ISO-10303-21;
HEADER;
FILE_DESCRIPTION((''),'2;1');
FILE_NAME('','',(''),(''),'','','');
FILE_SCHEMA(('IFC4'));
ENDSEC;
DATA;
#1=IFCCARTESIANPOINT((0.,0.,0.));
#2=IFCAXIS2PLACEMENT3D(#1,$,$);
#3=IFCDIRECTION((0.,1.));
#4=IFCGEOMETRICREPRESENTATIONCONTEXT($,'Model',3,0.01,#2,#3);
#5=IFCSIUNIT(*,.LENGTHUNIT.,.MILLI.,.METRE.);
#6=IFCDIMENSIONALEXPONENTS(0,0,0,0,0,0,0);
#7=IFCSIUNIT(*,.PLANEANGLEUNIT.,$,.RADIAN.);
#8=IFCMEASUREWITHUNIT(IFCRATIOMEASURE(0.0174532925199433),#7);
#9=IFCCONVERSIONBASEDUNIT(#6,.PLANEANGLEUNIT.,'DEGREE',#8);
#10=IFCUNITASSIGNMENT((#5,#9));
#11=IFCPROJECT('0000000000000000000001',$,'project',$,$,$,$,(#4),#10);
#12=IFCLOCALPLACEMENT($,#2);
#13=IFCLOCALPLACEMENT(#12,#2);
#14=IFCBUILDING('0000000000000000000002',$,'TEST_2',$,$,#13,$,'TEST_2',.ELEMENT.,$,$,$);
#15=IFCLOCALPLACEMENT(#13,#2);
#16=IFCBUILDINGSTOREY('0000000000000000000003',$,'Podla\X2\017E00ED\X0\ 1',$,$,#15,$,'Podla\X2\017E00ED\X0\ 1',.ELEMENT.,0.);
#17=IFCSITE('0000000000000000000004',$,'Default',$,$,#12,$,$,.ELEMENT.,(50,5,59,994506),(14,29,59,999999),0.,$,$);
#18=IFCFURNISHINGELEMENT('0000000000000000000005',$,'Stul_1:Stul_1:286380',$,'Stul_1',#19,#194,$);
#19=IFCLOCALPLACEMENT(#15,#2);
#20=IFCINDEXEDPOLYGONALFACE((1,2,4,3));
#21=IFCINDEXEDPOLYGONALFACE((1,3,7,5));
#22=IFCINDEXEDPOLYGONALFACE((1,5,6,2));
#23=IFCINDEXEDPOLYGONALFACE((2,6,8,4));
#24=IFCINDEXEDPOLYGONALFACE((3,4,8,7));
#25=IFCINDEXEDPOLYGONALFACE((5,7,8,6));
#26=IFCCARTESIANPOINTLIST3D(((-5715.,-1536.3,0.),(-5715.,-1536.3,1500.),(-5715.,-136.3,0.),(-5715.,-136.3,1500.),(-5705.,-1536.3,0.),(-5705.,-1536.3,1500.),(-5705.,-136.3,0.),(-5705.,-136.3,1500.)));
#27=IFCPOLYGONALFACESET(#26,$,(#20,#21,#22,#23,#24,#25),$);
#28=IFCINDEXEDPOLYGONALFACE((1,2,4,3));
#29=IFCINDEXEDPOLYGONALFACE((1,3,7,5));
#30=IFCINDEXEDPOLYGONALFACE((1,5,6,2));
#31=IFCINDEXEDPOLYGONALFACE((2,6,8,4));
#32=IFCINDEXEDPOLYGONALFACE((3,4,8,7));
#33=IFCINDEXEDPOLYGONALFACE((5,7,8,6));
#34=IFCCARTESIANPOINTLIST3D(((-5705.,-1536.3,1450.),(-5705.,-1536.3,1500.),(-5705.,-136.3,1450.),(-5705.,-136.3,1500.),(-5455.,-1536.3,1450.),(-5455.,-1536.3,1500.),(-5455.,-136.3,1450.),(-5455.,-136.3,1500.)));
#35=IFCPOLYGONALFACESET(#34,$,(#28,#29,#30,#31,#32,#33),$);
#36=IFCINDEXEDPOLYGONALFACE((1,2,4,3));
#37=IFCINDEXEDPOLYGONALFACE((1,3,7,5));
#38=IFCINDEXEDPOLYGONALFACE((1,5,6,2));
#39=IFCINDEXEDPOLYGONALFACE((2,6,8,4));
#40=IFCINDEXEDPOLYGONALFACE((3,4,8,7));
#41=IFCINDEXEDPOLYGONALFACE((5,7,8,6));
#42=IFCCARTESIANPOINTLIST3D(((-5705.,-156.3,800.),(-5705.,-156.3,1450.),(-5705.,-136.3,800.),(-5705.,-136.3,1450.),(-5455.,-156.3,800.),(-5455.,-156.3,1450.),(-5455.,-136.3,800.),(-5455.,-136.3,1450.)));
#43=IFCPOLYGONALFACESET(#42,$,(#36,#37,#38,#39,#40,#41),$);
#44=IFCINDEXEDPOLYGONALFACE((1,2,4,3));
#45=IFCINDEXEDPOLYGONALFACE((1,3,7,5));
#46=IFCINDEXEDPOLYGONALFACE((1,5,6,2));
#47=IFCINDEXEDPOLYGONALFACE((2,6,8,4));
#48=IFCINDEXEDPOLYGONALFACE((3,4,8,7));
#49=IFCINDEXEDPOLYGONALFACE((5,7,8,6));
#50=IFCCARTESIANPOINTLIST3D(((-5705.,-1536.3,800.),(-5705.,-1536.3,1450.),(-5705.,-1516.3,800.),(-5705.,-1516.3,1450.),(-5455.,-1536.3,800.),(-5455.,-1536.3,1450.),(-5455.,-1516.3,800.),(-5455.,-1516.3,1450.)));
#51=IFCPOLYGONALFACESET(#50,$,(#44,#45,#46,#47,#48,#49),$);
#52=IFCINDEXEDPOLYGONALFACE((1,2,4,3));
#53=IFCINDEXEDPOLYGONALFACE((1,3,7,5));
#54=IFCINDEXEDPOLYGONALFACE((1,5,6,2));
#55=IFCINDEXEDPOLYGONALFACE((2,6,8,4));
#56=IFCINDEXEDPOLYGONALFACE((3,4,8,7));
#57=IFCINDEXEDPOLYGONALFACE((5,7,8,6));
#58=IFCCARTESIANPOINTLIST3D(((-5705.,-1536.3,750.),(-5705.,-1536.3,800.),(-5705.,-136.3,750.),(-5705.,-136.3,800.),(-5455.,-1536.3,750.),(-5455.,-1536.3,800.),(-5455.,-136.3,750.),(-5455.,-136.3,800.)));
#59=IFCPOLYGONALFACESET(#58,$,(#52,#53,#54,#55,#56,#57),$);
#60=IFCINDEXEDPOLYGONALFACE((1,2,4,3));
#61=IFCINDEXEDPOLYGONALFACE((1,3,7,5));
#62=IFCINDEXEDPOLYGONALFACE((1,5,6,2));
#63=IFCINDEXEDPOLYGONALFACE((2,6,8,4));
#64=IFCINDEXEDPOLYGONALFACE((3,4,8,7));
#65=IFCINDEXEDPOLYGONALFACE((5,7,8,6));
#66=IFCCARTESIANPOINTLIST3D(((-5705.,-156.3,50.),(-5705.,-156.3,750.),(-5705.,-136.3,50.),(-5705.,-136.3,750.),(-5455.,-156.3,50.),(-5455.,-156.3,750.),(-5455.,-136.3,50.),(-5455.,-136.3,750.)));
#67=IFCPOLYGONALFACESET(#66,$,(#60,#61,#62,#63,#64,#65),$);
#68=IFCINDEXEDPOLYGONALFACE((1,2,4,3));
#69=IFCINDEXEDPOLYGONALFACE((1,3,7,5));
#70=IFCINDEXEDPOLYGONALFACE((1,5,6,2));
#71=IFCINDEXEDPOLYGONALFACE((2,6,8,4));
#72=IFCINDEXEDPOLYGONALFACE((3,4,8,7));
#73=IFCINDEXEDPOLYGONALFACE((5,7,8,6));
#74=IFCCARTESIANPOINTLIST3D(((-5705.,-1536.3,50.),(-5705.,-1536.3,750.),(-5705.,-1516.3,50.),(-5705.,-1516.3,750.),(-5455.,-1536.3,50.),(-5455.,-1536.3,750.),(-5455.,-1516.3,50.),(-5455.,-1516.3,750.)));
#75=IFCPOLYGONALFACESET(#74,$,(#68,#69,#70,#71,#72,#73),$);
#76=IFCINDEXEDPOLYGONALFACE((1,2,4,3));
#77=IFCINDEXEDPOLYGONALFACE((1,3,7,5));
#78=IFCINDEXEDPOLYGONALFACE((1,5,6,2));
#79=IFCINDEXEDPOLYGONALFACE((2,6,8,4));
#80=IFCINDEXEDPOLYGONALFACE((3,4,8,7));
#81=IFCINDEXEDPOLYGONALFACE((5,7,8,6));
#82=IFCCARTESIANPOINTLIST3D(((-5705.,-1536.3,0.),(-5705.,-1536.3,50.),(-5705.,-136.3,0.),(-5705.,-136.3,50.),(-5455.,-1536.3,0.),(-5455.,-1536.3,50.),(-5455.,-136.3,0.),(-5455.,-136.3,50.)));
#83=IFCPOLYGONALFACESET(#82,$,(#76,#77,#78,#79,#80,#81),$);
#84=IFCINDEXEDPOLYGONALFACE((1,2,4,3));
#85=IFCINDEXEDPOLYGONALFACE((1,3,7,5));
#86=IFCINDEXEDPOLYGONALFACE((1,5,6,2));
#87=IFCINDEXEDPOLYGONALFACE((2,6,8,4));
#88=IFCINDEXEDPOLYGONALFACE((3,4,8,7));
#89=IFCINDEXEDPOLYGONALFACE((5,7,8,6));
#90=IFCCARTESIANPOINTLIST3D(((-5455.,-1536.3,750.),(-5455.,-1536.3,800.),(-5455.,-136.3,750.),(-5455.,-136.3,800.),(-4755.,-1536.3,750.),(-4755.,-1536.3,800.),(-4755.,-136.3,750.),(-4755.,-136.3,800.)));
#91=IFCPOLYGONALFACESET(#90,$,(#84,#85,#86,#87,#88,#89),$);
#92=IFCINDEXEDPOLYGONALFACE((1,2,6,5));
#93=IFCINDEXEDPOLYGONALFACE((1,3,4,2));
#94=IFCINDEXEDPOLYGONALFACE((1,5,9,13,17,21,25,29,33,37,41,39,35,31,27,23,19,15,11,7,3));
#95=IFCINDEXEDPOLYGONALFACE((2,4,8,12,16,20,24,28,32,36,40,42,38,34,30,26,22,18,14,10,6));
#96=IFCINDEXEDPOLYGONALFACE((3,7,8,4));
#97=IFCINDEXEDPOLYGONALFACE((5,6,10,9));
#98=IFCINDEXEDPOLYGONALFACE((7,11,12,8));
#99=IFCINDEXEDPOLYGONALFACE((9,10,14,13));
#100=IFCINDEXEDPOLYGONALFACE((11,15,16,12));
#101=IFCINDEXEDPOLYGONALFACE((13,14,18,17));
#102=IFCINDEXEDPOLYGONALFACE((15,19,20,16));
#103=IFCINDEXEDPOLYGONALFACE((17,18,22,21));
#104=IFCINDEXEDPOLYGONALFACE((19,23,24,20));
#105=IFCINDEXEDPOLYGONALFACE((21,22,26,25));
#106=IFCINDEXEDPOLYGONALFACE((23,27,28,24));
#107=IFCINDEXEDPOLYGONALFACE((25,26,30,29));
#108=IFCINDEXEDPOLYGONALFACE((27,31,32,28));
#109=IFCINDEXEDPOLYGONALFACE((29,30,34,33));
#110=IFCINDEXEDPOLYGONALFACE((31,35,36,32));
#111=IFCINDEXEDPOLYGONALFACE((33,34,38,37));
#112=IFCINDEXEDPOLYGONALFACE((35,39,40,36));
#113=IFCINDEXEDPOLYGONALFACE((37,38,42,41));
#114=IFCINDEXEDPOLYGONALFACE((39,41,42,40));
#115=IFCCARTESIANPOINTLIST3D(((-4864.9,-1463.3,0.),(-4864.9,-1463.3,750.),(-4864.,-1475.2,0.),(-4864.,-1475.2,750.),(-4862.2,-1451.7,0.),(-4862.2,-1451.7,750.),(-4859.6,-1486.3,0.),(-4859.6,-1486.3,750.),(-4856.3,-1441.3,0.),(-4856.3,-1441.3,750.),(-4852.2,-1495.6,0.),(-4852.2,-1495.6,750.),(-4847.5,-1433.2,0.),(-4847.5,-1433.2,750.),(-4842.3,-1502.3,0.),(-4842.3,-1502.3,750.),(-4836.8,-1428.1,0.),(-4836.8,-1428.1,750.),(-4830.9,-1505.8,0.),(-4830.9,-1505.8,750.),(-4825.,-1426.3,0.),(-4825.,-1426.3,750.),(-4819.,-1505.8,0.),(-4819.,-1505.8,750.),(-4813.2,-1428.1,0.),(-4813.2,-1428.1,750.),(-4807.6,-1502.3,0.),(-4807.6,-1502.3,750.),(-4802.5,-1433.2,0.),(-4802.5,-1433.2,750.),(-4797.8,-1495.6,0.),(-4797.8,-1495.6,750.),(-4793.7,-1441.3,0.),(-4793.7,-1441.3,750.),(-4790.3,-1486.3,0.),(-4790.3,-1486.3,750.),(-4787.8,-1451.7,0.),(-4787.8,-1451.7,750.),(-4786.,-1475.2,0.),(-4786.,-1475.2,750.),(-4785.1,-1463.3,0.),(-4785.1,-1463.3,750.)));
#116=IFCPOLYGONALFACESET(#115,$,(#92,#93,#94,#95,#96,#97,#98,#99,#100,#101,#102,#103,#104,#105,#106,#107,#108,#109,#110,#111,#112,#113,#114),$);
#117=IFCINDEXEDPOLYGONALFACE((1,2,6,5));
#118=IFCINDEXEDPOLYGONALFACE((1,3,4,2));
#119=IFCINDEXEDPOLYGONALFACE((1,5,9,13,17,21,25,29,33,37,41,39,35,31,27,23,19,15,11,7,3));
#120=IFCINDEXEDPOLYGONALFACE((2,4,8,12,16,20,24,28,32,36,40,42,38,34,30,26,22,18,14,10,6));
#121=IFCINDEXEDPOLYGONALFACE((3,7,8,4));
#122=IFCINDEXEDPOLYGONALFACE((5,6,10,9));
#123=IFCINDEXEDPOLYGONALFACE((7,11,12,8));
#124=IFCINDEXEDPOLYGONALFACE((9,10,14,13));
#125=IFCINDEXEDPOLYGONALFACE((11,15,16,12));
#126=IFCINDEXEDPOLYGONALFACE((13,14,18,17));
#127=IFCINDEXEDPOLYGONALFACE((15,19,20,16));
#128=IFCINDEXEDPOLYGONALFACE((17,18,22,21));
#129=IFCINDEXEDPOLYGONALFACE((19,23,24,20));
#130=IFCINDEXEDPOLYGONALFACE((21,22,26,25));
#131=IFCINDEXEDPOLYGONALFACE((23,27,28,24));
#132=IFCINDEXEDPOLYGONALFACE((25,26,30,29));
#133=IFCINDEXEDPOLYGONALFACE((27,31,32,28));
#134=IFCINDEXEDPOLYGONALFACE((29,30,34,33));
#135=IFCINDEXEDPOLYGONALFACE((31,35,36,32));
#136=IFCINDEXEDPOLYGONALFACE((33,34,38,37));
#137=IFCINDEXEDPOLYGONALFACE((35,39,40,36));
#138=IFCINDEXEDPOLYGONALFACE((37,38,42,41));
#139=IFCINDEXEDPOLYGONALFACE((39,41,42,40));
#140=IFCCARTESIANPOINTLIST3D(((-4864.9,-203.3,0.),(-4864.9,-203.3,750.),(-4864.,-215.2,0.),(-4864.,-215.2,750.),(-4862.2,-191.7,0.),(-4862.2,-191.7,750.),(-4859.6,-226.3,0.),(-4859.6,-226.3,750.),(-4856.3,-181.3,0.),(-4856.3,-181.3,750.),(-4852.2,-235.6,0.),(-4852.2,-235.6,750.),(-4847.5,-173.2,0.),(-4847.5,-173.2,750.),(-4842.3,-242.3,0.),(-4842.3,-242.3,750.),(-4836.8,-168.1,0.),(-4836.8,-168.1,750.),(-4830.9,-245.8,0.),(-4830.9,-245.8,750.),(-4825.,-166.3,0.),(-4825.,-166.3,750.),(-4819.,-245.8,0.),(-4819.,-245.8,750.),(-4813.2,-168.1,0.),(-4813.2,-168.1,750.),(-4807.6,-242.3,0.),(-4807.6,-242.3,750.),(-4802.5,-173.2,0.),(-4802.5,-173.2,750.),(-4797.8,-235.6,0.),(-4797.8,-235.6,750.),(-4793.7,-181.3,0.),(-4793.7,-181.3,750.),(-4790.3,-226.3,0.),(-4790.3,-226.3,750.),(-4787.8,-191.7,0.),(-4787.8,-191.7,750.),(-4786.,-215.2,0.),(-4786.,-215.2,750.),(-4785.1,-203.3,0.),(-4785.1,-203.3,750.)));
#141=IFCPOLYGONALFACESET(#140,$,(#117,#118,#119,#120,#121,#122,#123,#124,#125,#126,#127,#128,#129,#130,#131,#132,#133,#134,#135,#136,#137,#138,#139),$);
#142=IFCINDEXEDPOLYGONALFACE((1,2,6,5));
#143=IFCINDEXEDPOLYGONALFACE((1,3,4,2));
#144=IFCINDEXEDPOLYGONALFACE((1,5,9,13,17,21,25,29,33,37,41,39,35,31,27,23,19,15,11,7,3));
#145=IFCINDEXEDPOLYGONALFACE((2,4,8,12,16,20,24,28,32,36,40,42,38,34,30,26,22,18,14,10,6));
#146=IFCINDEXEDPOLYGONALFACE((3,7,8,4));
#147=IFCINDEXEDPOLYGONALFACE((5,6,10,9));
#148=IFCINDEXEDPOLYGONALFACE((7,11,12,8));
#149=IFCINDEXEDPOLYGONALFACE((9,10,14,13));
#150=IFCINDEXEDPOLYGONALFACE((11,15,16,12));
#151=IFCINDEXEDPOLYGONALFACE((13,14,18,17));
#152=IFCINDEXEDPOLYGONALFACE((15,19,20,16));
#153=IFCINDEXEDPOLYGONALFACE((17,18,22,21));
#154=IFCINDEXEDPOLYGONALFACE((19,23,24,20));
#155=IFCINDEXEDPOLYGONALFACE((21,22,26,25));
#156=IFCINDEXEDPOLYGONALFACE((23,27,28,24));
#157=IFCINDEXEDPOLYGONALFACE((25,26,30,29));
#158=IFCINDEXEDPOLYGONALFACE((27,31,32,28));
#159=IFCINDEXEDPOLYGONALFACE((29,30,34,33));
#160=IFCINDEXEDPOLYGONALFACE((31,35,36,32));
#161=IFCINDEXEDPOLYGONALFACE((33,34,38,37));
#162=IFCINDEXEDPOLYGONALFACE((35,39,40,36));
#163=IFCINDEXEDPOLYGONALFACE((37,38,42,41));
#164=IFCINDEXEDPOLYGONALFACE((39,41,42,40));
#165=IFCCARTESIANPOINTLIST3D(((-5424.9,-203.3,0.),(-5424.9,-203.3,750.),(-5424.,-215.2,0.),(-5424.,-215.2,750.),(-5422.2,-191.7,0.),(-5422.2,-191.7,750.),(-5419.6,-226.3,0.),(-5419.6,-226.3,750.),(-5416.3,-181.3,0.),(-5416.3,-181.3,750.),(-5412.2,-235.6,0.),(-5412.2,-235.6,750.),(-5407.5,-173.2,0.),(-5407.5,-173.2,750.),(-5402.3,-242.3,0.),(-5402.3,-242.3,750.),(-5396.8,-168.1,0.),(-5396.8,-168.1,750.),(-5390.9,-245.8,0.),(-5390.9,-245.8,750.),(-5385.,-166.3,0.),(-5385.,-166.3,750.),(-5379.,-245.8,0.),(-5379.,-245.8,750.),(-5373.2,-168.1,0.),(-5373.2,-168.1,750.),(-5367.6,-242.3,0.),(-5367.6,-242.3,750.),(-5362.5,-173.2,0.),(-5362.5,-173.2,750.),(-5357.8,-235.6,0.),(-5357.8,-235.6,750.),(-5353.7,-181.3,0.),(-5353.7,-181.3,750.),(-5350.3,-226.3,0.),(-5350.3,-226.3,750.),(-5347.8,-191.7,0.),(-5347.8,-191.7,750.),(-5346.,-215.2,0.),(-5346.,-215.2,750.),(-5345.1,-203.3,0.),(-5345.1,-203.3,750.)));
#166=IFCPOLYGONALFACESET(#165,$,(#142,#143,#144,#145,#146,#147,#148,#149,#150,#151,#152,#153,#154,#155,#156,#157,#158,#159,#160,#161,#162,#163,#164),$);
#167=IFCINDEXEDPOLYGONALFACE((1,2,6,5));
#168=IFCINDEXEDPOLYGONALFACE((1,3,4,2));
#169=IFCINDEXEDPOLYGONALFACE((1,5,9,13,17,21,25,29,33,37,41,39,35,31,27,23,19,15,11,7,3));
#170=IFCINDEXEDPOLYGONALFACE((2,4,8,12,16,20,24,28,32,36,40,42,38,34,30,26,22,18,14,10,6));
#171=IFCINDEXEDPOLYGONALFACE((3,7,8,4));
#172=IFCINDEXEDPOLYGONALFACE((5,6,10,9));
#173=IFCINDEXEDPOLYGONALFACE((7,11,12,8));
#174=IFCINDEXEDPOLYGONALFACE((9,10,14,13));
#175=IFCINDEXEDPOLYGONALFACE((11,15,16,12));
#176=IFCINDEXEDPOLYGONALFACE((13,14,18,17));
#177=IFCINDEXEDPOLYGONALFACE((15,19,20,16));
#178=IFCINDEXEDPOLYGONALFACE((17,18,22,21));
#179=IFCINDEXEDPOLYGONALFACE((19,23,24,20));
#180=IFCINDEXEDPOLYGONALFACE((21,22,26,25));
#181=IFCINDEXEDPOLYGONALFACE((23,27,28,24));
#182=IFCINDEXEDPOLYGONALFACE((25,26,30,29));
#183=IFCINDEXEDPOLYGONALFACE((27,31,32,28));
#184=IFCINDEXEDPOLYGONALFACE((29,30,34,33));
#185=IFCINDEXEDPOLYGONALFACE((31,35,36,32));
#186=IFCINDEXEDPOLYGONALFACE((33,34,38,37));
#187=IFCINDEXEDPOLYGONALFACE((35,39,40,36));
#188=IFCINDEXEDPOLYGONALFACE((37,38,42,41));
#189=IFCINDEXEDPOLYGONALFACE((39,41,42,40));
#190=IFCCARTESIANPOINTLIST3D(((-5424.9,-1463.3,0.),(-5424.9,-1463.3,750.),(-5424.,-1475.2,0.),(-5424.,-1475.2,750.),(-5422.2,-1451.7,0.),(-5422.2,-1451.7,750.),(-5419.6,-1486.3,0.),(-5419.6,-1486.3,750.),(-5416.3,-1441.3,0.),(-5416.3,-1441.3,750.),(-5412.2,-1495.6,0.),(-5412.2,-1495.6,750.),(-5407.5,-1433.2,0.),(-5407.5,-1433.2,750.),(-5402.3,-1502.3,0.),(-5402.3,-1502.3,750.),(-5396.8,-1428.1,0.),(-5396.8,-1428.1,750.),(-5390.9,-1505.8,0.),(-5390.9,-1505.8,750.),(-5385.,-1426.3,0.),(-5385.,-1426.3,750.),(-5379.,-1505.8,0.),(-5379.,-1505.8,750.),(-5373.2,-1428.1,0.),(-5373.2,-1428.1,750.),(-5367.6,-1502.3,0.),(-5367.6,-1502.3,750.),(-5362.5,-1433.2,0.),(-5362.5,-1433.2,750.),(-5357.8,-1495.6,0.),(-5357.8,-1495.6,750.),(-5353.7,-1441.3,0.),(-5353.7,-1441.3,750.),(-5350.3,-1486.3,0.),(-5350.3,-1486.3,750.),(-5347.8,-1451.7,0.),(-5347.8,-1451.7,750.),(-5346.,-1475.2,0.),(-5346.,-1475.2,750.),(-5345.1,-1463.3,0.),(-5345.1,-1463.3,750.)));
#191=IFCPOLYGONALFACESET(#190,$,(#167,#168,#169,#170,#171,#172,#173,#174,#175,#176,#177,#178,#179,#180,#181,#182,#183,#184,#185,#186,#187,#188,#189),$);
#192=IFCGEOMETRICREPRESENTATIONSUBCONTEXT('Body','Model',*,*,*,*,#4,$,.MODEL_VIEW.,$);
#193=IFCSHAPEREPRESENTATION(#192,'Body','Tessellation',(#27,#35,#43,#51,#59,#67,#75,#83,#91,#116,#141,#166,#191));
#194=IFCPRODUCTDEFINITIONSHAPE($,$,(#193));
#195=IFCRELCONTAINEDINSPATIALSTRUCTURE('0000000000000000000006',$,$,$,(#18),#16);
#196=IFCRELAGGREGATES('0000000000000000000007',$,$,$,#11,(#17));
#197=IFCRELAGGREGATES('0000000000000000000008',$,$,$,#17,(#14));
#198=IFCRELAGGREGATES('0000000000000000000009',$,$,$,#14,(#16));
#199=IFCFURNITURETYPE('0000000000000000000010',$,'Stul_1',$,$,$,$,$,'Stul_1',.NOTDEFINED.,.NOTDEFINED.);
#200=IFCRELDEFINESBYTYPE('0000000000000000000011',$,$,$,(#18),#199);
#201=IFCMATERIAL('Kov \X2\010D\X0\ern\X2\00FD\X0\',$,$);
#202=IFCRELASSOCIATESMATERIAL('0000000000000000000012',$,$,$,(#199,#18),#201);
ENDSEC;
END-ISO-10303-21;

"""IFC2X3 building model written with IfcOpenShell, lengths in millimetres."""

from ifc_helpers import new_model, entity, si_unit, converted_unit, direction, frame, frame_2d, origin, origin_2d_with_axis, place, context, subcontext, project, spatial, rectangle, circle, extrude, source, transform, mapped, material, type_object, type_shapes, element, save


model = new_model("IFC2X3")

# Units and contexts
model_context = context("Model", 3, precision=0.01, world=origin(), true_north=direction((0.0, 1.0)))
body_context = subcontext(model_context, "Body", "Model", "MODEL_VIEW")
ifc_project = project(units=[si_unit("LENGTHUNIT", "METRE", prefix="MILLI"), converted_unit("PLANEANGLEUNIT", "DEGREE", entity("IfcRatioMeasure", 0.0174532925199433), si_unit("PLANEANGLEUNIT", "RADIAN"), dimensions=[0, 0, 0, 0, 0, 0, 0])], contexts=[model_context])

# Site, building, storey
site_placement = place(None, origin())
site = spatial("IfcSite", under=ifc_project, at=site_placement, Name="Default", CompositionType="ELEMENT", RefLatitude=(50, 5, 59, 994506), RefLongitude=(14, 29, 59, 999999), RefElevation=0.0)
building_placement = place(site_placement, origin())
building = spatial("IfcBuilding", under=site, at=building_placement, Name="TEST_2", LongName="TEST_2", CompositionType="ELEMENT")
storey_placement = place(building_placement, origin())
storey = spatial("IfcBuildingStorey", under=building, at=storey_placement, Name="Podlaží 1", LongName="Podlaží 1", CompositionType="ELEMENT", Elevation=0.0)

# Furnishing element
ifc_material_1 = material(Name="Kov černý")
furniture_type = type_object("IfcFurnitureType", Name="Stul_1", ElementType="Stul_1", material=ifc_material_1)
shared_shape_1 = source(origin(), body_context, "Body", "SweptSolid", [
    extrude(rectangle(XDim=1400.0, YDim=10.0, at=origin_2d_with_axis()), frame((0.0, 605.0, 0.0), z_axis=(0.0, 0.0, 1.0), x_axis=(-1.0, 0.0, 0.0)), (0.0, 0.0, 1.0), 1500.0),
    extrude(rectangle(XDim=1400.0, YDim=250.0, at=frame_2d((0.0, 0.0), x_axis=(1.0, 0.0))), frame((0.0, 475.0, 1450.0), z_axis=(0.0, 0.0, 1.0), x_axis=(-1.0, 0.0, 0.0)), (0.0, 0.0, 1.0), 50.0),
    extrude(rectangle(XDim=20.0, YDim=250.0, at=origin_2d_with_axis()), frame((690.0, 475.0, 800.0), z_axis=(0.0, 0.0, 1.0), x_axis=(-1.0, 0.0, 0.0)), (0.0, 0.0, 1.0), 650.0),
    extrude(rectangle(XDim=20.0, YDim=250.0, at=frame_2d((0.0, 0.0), x_axis=(1.0, 0.0))), frame((-690.0, 475.0, 800.0), z_axis=(0.0, 0.0, 1.0), x_axis=(-1.0, 0.0, 0.0)), (0.0, 0.0, 1.0), 650.0),
    extrude(rectangle(XDim=1400.0, YDim=250.0, at=origin_2d_with_axis()), frame((0.0, 475.0, 750.0), z_axis=(0.0, 0.0, 1.0), x_axis=(-1.0, 0.0, 0.0)), (0.0, 0.0, 1.0), 50.0),
    extrude(rectangle(XDim=20.0, YDim=250.0, at=origin_2d_with_axis()), frame((690.0, 475.0, 50.0), z_axis=(0.0, 0.0, 1.0), x_axis=(-1.0, 0.0, 0.0)), (0.0, 0.0, 1.0), 700.0),
    extrude(rectangle(XDim=20.0, YDim=250.0, at=frame_2d((0.0, 0.0), x_axis=(1.0, 0.0))), frame((-690.0, 475.0, 50.0), z_axis=(0.0, 0.0, 1.0), x_axis=(-1.0, 0.0, 0.0)), (0.0, 0.0, 1.0), 700.0),
    extrude(rectangle(XDim=1400.0, YDim=250.0, at=origin_2d_with_axis()), frame((0.0, 475.0, 0.0), z_axis=(0.0, 0.0, 1.0), x_axis=(-1.0, 0.0, 0.0)), (0.0, 0.0, 1.0), 50.0),
    extrude(rectangle(XDim=1400.0, YDim=700.0, at=origin_2d_with_axis()), frame((0.0, 0.0, 750.0), z_axis=(0.0, 0.0, 1.0), x_axis=(-1.0, 0.0, 0.0)), (0.0, 0.0, 1.0), 50.0),
    extrude(circle(Radius=40.0, at=frame_2d((0.0, 0.0), x_axis=(1.0, 0.0))), frame((-630.0, -280.0, 0.0)), (0.0, 0.0, 1.0), 750.0),
    extrude(circle(Radius=40.0, at=frame_2d((0.0, 0.0), x_axis=(1.0, 0.0))), frame((630.0, -280.0, 0.0)), (0.0, 0.0, 1.0), 750.0),
    extrude(circle(Radius=40.0, at=frame_2d((0.0, 0.0), x_axis=(1.0, 0.0))), frame((630.0, 280.0, 0.0)), (0.0, 0.0, 1.0), 750.0),
    extrude(circle(Radius=40.0, at=frame_2d((0.0, 0.0), x_axis=(1.0, 0.0))), frame((-630.0, 280.0, 0.0)), (0.0, 0.0, 1.0), 750.0),
])
type_shapes(furniture_type, [shared_shape_1])
for number, where, z_axis, x_axis, name in (
    (1, (-5105.0, -836.3, 0.0), (0.0, 0.0, 1.0), (0.0, 1.0, 0.0), "Stul_1:Stul_1:286380"),
):
    element("IfcFurnishingElement", number, at=place(storey_placement, frame(where, z_axis=z_axis, x_axis=x_axis)), inside=storey, type_object=furniture_type, material=ifc_material_1, Name=name, ObjectType="Stul_1", context=body_context, shape_type="MappedRepresentation", body=[
        mapped(shared_shape_1, transform((0.0, 0.0, 0.0), scale=1.0)),
    ])

save(model, "model.ifc")
